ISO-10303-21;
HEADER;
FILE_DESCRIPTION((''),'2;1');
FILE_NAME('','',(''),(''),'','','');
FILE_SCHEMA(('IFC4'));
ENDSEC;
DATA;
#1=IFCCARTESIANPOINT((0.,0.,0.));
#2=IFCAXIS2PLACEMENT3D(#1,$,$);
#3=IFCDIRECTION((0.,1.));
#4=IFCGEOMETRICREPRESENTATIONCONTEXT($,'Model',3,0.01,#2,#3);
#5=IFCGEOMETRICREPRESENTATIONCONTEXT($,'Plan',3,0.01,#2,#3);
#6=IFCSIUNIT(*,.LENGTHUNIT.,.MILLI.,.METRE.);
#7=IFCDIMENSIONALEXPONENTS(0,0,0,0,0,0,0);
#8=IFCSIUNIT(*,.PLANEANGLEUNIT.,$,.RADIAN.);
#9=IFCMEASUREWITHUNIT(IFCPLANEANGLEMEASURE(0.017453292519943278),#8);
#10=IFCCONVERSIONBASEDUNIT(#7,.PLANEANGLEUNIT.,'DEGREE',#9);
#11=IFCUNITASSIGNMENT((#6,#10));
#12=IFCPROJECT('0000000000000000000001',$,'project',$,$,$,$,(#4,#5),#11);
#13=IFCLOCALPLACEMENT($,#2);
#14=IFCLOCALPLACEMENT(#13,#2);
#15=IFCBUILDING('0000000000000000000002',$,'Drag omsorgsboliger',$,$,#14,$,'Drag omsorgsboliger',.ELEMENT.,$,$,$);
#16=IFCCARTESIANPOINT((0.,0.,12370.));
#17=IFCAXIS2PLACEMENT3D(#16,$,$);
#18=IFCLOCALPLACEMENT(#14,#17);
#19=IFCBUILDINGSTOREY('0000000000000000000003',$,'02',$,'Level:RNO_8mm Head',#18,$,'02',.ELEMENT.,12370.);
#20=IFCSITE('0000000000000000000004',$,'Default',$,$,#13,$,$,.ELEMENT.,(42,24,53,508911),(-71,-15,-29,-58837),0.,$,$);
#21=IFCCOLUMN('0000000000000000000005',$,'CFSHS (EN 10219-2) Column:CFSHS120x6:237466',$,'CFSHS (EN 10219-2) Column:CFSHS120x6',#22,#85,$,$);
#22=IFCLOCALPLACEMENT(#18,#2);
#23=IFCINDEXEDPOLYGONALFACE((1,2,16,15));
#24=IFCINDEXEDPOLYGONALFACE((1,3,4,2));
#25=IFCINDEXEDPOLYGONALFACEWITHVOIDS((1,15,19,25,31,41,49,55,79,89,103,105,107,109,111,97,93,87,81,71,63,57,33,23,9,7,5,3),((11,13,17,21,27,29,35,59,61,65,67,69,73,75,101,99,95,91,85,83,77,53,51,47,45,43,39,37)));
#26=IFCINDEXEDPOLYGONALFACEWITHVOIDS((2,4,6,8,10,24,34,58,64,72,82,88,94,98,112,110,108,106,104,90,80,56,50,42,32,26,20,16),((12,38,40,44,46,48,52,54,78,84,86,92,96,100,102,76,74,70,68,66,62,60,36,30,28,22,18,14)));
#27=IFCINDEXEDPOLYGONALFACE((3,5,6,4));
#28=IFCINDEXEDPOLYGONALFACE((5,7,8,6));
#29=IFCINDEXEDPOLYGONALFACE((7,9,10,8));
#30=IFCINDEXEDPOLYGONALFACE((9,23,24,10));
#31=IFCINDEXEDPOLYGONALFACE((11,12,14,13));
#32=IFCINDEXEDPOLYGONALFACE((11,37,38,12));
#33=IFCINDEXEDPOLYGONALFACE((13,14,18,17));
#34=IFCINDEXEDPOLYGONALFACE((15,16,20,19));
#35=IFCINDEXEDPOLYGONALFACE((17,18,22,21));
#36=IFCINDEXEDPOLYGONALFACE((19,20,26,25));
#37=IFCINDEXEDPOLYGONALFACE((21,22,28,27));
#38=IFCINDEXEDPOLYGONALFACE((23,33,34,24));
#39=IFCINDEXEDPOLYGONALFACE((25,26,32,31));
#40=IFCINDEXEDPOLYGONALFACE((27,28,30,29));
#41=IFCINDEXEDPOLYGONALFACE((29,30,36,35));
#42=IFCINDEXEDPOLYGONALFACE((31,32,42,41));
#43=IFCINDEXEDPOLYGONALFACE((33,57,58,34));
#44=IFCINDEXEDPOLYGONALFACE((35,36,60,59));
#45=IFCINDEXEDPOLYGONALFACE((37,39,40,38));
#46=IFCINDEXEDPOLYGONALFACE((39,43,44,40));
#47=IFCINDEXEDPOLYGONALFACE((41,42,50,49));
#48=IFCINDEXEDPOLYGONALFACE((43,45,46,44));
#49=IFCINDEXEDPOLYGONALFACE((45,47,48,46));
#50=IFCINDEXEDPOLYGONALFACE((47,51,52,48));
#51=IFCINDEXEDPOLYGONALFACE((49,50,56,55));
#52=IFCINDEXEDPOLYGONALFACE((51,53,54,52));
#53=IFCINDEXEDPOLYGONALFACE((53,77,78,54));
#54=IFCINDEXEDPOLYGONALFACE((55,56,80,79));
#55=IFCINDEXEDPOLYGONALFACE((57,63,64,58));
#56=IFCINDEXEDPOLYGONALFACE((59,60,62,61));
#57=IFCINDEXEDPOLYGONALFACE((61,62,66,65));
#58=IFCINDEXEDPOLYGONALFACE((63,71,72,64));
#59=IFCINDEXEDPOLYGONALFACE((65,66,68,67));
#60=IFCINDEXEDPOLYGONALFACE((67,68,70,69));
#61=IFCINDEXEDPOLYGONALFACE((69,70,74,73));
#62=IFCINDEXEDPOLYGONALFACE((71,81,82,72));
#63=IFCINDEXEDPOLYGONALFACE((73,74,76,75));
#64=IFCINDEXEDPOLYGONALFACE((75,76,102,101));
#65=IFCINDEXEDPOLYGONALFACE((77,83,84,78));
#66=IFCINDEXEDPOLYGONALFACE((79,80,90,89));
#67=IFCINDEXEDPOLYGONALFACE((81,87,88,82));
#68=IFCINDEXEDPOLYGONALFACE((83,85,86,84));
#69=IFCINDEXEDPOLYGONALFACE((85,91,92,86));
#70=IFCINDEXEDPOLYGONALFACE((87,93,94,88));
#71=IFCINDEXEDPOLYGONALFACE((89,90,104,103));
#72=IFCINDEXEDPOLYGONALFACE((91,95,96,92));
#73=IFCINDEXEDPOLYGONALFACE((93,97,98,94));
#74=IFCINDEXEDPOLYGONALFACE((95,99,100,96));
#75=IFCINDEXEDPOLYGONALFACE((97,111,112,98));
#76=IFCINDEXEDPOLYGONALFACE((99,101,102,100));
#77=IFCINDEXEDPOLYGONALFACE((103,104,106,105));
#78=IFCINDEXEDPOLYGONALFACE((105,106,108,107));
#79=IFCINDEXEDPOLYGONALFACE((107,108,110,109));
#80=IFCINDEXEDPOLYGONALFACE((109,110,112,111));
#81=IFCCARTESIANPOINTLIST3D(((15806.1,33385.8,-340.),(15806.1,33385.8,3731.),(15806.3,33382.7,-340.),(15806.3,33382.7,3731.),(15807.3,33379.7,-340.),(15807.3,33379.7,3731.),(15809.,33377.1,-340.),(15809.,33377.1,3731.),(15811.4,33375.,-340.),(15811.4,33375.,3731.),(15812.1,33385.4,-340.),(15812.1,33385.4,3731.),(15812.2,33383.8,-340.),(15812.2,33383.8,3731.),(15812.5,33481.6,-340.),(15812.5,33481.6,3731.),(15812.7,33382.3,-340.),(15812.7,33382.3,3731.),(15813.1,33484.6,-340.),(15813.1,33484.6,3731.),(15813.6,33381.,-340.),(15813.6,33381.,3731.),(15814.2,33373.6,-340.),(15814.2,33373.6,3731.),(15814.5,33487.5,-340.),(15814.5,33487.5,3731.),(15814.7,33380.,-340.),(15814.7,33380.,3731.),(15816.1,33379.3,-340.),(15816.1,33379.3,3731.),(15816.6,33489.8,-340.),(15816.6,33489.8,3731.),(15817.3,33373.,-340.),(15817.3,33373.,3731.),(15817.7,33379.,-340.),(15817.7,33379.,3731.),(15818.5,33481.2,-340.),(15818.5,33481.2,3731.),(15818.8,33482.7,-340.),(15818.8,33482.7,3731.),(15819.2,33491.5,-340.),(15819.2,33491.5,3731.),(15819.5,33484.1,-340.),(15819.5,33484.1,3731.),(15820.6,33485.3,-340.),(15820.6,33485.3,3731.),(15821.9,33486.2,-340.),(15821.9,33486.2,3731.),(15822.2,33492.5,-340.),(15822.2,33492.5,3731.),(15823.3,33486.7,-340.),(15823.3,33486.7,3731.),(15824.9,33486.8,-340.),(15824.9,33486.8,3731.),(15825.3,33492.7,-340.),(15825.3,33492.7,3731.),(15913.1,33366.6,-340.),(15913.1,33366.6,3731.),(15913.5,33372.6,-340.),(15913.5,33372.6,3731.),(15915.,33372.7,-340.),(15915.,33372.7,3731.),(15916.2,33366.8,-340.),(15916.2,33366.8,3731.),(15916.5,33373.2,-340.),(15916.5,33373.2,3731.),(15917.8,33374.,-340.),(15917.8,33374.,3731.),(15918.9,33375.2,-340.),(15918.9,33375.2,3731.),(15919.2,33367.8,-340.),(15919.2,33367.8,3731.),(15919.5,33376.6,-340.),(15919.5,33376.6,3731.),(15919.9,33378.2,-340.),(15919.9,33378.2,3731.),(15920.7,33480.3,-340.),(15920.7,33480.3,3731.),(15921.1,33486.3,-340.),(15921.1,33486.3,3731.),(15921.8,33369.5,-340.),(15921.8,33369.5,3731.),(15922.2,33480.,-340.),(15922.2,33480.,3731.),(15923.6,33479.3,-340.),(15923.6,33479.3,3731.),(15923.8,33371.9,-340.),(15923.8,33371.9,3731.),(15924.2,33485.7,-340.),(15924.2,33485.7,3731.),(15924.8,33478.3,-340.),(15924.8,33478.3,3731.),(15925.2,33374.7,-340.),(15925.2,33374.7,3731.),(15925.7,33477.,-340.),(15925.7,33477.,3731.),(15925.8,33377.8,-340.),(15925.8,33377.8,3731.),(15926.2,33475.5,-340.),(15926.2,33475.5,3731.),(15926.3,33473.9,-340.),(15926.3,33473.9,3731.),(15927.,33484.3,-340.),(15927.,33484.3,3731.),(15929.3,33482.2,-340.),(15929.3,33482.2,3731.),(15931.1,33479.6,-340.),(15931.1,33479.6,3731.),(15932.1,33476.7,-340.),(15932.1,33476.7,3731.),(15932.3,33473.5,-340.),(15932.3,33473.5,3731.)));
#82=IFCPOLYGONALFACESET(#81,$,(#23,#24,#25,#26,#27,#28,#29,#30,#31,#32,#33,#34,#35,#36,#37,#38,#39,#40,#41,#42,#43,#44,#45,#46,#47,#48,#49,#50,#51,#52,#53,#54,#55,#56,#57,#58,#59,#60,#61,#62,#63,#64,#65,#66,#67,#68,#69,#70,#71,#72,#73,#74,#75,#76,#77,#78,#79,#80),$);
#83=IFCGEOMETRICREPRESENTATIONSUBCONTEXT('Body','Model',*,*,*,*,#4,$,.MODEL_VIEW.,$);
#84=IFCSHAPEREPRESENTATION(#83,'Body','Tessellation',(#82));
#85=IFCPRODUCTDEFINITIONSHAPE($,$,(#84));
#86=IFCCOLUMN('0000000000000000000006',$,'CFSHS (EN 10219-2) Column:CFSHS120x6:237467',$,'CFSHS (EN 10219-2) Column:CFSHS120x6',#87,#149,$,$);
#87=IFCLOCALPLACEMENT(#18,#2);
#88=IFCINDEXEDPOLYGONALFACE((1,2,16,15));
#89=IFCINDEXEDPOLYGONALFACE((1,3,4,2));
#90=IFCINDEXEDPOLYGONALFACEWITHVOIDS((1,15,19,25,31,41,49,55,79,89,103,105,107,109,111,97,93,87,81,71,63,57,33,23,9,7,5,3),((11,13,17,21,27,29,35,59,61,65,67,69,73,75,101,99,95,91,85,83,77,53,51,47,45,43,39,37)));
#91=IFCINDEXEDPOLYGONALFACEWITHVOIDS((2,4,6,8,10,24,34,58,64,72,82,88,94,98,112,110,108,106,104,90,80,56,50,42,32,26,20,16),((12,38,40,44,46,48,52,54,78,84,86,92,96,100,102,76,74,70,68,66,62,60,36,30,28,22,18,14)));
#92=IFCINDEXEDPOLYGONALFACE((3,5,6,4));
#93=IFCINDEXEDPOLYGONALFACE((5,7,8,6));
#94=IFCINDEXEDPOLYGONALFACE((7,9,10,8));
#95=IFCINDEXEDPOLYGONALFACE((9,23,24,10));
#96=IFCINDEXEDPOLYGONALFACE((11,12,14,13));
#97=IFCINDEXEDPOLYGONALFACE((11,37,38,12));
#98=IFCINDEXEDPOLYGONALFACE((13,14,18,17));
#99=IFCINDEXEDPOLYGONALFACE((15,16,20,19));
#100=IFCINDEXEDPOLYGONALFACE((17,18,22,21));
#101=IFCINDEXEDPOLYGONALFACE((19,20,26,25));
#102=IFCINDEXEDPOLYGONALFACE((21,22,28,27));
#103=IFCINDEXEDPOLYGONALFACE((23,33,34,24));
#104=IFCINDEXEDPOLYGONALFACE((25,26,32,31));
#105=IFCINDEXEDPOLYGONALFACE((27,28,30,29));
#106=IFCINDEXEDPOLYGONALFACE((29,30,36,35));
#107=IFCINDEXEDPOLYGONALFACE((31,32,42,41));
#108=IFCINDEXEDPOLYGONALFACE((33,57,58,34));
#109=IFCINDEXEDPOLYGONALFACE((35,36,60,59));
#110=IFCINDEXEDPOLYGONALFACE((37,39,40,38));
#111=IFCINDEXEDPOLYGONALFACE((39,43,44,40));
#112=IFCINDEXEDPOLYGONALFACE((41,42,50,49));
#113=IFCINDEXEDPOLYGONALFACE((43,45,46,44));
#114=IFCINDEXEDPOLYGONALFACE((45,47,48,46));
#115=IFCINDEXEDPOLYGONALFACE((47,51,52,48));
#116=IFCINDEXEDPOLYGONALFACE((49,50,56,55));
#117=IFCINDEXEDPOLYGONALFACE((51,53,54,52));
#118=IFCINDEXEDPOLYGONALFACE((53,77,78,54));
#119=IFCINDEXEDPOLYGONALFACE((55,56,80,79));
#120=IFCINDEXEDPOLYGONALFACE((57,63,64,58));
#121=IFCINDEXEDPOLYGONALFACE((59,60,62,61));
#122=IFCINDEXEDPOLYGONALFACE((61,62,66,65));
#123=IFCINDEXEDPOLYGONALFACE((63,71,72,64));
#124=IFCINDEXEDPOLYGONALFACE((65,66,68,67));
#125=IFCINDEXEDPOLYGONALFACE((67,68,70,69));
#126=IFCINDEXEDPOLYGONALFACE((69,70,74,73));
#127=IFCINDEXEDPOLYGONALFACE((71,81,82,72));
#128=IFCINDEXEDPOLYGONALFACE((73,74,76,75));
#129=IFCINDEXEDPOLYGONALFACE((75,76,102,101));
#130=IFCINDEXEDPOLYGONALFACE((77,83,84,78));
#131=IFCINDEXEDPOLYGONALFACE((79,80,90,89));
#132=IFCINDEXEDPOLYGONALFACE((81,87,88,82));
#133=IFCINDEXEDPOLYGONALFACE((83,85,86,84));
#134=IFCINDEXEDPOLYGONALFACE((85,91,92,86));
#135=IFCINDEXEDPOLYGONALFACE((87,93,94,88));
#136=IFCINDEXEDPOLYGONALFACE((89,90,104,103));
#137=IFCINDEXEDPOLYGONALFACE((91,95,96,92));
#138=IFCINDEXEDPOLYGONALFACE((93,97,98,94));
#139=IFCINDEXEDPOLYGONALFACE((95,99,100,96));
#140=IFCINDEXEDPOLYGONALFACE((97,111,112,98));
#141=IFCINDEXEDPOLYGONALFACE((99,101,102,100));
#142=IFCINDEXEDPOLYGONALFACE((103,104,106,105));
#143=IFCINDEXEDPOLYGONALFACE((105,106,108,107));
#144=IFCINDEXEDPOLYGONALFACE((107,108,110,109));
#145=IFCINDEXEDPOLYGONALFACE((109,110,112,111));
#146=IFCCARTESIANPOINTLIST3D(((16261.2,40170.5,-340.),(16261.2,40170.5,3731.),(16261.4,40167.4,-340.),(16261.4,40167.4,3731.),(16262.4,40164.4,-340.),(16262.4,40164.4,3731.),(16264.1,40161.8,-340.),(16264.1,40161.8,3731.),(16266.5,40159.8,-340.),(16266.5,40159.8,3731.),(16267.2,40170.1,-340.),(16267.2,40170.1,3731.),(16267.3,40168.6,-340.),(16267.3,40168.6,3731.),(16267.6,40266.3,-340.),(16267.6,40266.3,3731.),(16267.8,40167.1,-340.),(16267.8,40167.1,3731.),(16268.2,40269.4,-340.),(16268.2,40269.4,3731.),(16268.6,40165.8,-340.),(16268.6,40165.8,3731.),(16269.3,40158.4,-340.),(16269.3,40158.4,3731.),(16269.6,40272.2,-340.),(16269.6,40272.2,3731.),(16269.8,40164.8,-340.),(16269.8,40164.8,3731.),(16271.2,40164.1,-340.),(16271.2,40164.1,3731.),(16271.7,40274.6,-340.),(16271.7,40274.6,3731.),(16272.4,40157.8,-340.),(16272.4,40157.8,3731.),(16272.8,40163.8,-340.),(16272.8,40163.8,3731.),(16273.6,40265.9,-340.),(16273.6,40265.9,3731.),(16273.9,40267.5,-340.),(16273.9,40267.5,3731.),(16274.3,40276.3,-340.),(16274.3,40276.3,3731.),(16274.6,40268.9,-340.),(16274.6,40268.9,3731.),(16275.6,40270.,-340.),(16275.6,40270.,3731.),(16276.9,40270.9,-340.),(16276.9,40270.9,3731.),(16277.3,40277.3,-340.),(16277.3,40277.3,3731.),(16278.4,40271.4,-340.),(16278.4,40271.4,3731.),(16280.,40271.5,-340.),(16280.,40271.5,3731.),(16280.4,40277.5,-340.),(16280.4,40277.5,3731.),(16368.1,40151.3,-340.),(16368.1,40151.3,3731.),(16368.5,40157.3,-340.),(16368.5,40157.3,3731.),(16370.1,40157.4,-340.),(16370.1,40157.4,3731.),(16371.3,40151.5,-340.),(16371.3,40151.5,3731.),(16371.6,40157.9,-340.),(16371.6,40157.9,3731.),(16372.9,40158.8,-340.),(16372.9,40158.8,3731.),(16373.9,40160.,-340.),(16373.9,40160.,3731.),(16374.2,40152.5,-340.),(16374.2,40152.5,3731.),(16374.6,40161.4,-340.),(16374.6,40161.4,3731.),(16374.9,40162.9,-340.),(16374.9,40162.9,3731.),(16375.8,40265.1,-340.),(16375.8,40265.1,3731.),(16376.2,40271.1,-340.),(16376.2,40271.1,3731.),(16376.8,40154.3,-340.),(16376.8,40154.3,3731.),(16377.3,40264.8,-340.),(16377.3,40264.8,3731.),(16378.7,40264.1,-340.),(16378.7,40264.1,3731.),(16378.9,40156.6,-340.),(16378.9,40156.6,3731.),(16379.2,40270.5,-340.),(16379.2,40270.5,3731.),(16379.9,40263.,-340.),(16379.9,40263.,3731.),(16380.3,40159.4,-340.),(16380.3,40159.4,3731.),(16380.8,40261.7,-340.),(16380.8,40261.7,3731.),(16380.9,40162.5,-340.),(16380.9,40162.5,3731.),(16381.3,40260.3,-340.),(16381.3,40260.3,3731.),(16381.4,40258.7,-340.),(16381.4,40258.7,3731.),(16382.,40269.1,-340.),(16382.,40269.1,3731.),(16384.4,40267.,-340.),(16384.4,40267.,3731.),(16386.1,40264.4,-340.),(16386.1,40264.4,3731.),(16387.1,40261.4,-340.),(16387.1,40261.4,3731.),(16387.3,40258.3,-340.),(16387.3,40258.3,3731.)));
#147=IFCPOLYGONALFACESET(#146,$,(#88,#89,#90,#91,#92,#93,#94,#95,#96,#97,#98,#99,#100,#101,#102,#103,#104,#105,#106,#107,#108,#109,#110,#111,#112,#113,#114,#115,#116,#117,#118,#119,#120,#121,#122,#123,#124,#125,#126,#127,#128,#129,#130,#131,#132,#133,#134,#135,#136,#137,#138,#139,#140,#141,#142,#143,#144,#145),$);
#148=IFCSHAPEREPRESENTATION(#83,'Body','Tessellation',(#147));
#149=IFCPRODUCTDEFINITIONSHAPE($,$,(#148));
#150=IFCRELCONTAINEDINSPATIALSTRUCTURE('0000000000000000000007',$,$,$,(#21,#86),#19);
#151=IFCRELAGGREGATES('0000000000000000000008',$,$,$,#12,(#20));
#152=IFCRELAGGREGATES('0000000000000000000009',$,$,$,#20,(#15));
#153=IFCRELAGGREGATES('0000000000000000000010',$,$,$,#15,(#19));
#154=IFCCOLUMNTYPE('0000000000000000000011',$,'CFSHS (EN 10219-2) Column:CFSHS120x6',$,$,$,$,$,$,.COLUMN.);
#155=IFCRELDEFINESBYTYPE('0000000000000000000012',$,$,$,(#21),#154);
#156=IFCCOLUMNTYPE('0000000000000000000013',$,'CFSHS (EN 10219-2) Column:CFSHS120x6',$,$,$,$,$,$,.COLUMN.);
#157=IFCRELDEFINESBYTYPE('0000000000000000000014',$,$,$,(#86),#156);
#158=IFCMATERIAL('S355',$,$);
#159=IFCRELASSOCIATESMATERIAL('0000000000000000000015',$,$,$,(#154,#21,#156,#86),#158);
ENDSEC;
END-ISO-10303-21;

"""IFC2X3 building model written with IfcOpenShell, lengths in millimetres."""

from ifc_helpers import new_model, entity, si_unit, converted_unit, direction, frame, frame_2d, origin, place, context, subcontext, project, spatial, polyline, circle_curve, parameter, trimmed, segment, composite_curve, outline, extrude, source, transform, mapped, material, type_object, type_shapes, element, save


model = new_model("IFC2X3")

# Units and contexts
model_context = context("Model", 3, precision=0.01, world=origin(), true_north=direction((0.0, 1.0)))
plan_context = context("Plan", 3, precision=0.01, world=origin(), true_north=direction((0.0, 1.0)))
body_context = subcontext(model_context, "Body", "Model", "MODEL_VIEW")
ifc_project = project(units=[si_unit("LENGTHUNIT", "METRE", prefix="MILLI"), converted_unit("PLANEANGLEUNIT", "DEGREE", entity("IfcPlaneAngleMeasure", 0.017453292519943278), si_unit("PLANEANGLEUNIT", "RADIAN"), dimensions=[0, 0, 0, 0, 0, 0, 0])], contexts=[model_context, plan_context])

# Site, building, storey
site_placement = place(None, origin())
site = spatial("IfcSite", under=ifc_project, at=site_placement, Name="Default", CompositionType="ELEMENT", RefLatitude=(42, 24, 53, 508911), RefLongitude=(-71, -15, -29, -58837), RefElevation=0.0)
building_placement = place(site_placement, origin())
building = spatial("IfcBuilding", under=site, at=building_placement, Name="Drag omsorgsboliger", LongName="Drag omsorgsboliger", CompositionType="ELEMENT")
storey_placement = place(building_placement, frame((0.0, 0.0, 12370.0)))
storey = spatial("IfcBuildingStorey", under=building, at=storey_placement, Name="02", ObjectType="Level:RNO_8mm Head", LongName="02", CompositionType="ELEMENT", Elevation=12370.0)

# Columns
ifc_material = material(Name="S355")
column_type_1 = type_object("IfcColumnType", Name="CFSHS (EN 10219-2) Column:CFSHS120x6", PredefinedType="COLUMN", material=ifc_material)
shared_shape_1 = source(origin(), body_context, "Body", "SweptSolid", [
    extrude(outline(composite_curve([segment(polyline([(-48.0, -60.0), (48.0, -60.0)]), True, "CONTINUOUS"), segment(trimmed(circle_curve(frame_2d((48.0, -48.0), x_axis=(-1.0, 0.0)), 12.0), [parameter(90.0)], [parameter(180.0)], True, "PARAMETER"), True, "CONTINUOUS"), segment(polyline([(60.0, -48.0), (60.0, 48.0)]), True, "CONTINUOUS"), segment(trimmed(circle_curve(frame_2d((48.0, 48.0), x_axis=(-1.0, 0.0)), 12.0), [parameter(180.0)], [parameter(270.0)], True, "PARAMETER"), True, "CONTINUOUS"), segment(polyline([(48.0, 60.0), (-48.0, 60.0)]), True, "CONTINUOUS"), segment(trimmed(circle_curve(frame_2d((-48.0, 48.0), x_axis=(-1.0, 0.0)), 12.0), [parameter(270.0)], [parameter(360.0)], True, "PARAMETER"), True, "CONTINUOUS"), segment(polyline([(-60.0, 48.0), (-60.0, -48.0)]), True, "CONTINUOUS"), segment(trimmed(circle_curve(frame_2d((-48.0, -48.0), x_axis=(-1.0, 0.0)), 12.0), [parameter(360.0)], [parameter(90.0)], True, "PARAMETER"), True, "CONTINUOUS")], self_intersect=False), holes=[composite_curve([segment(trimmed(circle_curve(frame_2d((-48.0, -48.0), x_axis=(-1.0, 0.0)), 6.0), [parameter(360.0)], [parameter(90.0)], True, "PARAMETER"), False, "CONTINUOUS"), segment(polyline([(-54.0, -48.0), (-54.0, 48.0)]), True, "CONTINUOUS"), segment(trimmed(circle_curve(frame_2d((-48.0, 48.0), x_axis=(-1.0, 0.0)), 6.0), [parameter(270.0)], [parameter(360.0)], True, "PARAMETER"), False, "CONTINUOUS"), segment(polyline([(-48.0, 54.0), (48.0, 54.0)]), True, "CONTINUOUS"), segment(trimmed(circle_curve(frame_2d((48.0, 48.0), x_axis=(-1.0, 0.0)), 6.0), [parameter(180.0)], [parameter(270.0)], True, "PARAMETER"), False, "CONTINUOUS"), segment(polyline([(54.0, 48.0), (54.0, -48.0)]), True, "CONTINUOUS"), segment(trimmed(circle_curve(frame_2d((48.0, -48.0), x_axis=(-1.0, 0.0)), 6.0), [parameter(90.0)], [parameter(180.0)], True, "PARAMETER"), False, "CONTINUOUS"), segment(polyline([(48.0, -54.0), (-48.0, -54.0)]), True, "CONTINUOUS")], self_intersect=False)]), frame((15869.2, 33429.7, 12030.0), z_axis=(0.0, 0.0, 1.0), x_axis=(-0.997758, 0.066923, 0.0)), (0.0, 0.0, 1.0), 4071.0),
])
type_shapes(column_type_1, [shared_shape_1])
column_1_placement = place(storey_placement, frame((0.0, 0.0, -12370.0)))
element("IfcColumn", 1, at=column_1_placement, inside=storey, type_object=column_type_1, material=ifc_material, Name="CFSHS (EN 10219-2) Column:CFSHS120x6:237466", ObjectType="CFSHS (EN 10219-2) Column:CFSHS120x6", context=body_context, shape_type="MappedRepresentation", body=[
    mapped(shared_shape_1, transform((0.0, 0.0, 0.0), scale=1.0)),
])
column_type_2 = type_object("IfcColumnType", Name="CFSHS (EN 10219-2) Column:CFSHS120x6", PredefinedType="COLUMN", material=ifc_material)
shared_shape_2 = source(origin(), body_context, "Body", "SweptSolid", [
    extrude(outline(composite_curve([segment(polyline([(-48.0, -60.0), (48.0, -60.0)]), True, "CONTINUOUS"), segment(trimmed(circle_curve(frame_2d((48.0, -48.0), x_axis=(-1.0, 0.0)), 12.0), [parameter(90.0)], [parameter(180.0)], True, "PARAMETER"), True, "CONTINUOUS"), segment(polyline([(60.0, -48.0), (60.0, 48.0)]), True, "CONTINUOUS"), segment(trimmed(circle_curve(frame_2d((48.0, 48.0), x_axis=(-1.0, 0.0)), 12.0), [parameter(180.0)], [parameter(270.0)], True, "PARAMETER"), True, "CONTINUOUS"), segment(polyline([(48.0, 60.0), (-48.0, 60.0)]), True, "CONTINUOUS"), segment(trimmed(circle_curve(frame_2d((-48.0, 48.0), x_axis=(-1.0, 0.0)), 12.0), [parameter(270.0)], [parameter(360.0)], True, "PARAMETER"), True, "CONTINUOUS"), segment(polyline([(-60.0, 48.0), (-60.0, -48.0)]), True, "CONTINUOUS"), segment(trimmed(circle_curve(frame_2d((-48.0, -48.0), x_axis=(-1.0, 0.0)), 12.0), [parameter(360.0)], [parameter(90.0)], True, "PARAMETER"), True, "CONTINUOUS")], self_intersect=False), holes=[composite_curve([segment(trimmed(circle_curve(frame_2d((-48.0, -48.0), x_axis=(-1.0, 0.0)), 6.0), [parameter(360.0)], [parameter(90.0)], True, "PARAMETER"), False, "CONTINUOUS"), segment(polyline([(-54.0, -48.0), (-54.0, 48.0)]), True, "CONTINUOUS"), segment(trimmed(circle_curve(frame_2d((-48.0, 48.0), x_axis=(-1.0, 0.0)), 6.0), [parameter(270.0)], [parameter(360.0)], True, "PARAMETER"), False, "CONTINUOUS"), segment(polyline([(-48.0, 54.0), (48.0, 54.0)]), True, "CONTINUOUS"), segment(trimmed(circle_curve(frame_2d((48.0, 48.0), x_axis=(-1.0, 0.0)), 6.0), [parameter(180.0)], [parameter(270.0)], True, "PARAMETER"), False, "CONTINUOUS"), segment(polyline([(54.0, 48.0), (54.0, -48.0)]), True, "CONTINUOUS"), segment(trimmed(circle_curve(frame_2d((48.0, -48.0), x_axis=(-1.0, 0.0)), 6.0), [parameter(90.0)], [parameter(180.0)], True, "PARAMETER"), False, "CONTINUOUS"), segment(polyline([(48.0, -54.0), (-48.0, -54.0)]), True, "CONTINUOUS")], self_intersect=False)]), frame((16324.3, 40214.4, 12030.0), z_axis=(0.0, 0.0, 1.0), x_axis=(-0.997758, 0.066923, 0.0)), (0.0, 0.0, 1.0), 4071.0),
])
type_shapes(column_type_2, [shared_shape_2])
column_2_placement = place(storey_placement, frame((0.0, 0.0, -12370.0)))
element("IfcColumn", 2, at=column_2_placement, inside=storey, type_object=column_type_2, material=ifc_material, Name="CFSHS (EN 10219-2) Column:CFSHS120x6:237467", ObjectType="CFSHS (EN 10219-2) Column:CFSHS120x6", context=body_context, shape_type="MappedRepresentation", body=[
    mapped(shared_shape_2, transform((0.0, 0.0, 0.0), scale=1.0)),
])

save(model, "model.ifc")
